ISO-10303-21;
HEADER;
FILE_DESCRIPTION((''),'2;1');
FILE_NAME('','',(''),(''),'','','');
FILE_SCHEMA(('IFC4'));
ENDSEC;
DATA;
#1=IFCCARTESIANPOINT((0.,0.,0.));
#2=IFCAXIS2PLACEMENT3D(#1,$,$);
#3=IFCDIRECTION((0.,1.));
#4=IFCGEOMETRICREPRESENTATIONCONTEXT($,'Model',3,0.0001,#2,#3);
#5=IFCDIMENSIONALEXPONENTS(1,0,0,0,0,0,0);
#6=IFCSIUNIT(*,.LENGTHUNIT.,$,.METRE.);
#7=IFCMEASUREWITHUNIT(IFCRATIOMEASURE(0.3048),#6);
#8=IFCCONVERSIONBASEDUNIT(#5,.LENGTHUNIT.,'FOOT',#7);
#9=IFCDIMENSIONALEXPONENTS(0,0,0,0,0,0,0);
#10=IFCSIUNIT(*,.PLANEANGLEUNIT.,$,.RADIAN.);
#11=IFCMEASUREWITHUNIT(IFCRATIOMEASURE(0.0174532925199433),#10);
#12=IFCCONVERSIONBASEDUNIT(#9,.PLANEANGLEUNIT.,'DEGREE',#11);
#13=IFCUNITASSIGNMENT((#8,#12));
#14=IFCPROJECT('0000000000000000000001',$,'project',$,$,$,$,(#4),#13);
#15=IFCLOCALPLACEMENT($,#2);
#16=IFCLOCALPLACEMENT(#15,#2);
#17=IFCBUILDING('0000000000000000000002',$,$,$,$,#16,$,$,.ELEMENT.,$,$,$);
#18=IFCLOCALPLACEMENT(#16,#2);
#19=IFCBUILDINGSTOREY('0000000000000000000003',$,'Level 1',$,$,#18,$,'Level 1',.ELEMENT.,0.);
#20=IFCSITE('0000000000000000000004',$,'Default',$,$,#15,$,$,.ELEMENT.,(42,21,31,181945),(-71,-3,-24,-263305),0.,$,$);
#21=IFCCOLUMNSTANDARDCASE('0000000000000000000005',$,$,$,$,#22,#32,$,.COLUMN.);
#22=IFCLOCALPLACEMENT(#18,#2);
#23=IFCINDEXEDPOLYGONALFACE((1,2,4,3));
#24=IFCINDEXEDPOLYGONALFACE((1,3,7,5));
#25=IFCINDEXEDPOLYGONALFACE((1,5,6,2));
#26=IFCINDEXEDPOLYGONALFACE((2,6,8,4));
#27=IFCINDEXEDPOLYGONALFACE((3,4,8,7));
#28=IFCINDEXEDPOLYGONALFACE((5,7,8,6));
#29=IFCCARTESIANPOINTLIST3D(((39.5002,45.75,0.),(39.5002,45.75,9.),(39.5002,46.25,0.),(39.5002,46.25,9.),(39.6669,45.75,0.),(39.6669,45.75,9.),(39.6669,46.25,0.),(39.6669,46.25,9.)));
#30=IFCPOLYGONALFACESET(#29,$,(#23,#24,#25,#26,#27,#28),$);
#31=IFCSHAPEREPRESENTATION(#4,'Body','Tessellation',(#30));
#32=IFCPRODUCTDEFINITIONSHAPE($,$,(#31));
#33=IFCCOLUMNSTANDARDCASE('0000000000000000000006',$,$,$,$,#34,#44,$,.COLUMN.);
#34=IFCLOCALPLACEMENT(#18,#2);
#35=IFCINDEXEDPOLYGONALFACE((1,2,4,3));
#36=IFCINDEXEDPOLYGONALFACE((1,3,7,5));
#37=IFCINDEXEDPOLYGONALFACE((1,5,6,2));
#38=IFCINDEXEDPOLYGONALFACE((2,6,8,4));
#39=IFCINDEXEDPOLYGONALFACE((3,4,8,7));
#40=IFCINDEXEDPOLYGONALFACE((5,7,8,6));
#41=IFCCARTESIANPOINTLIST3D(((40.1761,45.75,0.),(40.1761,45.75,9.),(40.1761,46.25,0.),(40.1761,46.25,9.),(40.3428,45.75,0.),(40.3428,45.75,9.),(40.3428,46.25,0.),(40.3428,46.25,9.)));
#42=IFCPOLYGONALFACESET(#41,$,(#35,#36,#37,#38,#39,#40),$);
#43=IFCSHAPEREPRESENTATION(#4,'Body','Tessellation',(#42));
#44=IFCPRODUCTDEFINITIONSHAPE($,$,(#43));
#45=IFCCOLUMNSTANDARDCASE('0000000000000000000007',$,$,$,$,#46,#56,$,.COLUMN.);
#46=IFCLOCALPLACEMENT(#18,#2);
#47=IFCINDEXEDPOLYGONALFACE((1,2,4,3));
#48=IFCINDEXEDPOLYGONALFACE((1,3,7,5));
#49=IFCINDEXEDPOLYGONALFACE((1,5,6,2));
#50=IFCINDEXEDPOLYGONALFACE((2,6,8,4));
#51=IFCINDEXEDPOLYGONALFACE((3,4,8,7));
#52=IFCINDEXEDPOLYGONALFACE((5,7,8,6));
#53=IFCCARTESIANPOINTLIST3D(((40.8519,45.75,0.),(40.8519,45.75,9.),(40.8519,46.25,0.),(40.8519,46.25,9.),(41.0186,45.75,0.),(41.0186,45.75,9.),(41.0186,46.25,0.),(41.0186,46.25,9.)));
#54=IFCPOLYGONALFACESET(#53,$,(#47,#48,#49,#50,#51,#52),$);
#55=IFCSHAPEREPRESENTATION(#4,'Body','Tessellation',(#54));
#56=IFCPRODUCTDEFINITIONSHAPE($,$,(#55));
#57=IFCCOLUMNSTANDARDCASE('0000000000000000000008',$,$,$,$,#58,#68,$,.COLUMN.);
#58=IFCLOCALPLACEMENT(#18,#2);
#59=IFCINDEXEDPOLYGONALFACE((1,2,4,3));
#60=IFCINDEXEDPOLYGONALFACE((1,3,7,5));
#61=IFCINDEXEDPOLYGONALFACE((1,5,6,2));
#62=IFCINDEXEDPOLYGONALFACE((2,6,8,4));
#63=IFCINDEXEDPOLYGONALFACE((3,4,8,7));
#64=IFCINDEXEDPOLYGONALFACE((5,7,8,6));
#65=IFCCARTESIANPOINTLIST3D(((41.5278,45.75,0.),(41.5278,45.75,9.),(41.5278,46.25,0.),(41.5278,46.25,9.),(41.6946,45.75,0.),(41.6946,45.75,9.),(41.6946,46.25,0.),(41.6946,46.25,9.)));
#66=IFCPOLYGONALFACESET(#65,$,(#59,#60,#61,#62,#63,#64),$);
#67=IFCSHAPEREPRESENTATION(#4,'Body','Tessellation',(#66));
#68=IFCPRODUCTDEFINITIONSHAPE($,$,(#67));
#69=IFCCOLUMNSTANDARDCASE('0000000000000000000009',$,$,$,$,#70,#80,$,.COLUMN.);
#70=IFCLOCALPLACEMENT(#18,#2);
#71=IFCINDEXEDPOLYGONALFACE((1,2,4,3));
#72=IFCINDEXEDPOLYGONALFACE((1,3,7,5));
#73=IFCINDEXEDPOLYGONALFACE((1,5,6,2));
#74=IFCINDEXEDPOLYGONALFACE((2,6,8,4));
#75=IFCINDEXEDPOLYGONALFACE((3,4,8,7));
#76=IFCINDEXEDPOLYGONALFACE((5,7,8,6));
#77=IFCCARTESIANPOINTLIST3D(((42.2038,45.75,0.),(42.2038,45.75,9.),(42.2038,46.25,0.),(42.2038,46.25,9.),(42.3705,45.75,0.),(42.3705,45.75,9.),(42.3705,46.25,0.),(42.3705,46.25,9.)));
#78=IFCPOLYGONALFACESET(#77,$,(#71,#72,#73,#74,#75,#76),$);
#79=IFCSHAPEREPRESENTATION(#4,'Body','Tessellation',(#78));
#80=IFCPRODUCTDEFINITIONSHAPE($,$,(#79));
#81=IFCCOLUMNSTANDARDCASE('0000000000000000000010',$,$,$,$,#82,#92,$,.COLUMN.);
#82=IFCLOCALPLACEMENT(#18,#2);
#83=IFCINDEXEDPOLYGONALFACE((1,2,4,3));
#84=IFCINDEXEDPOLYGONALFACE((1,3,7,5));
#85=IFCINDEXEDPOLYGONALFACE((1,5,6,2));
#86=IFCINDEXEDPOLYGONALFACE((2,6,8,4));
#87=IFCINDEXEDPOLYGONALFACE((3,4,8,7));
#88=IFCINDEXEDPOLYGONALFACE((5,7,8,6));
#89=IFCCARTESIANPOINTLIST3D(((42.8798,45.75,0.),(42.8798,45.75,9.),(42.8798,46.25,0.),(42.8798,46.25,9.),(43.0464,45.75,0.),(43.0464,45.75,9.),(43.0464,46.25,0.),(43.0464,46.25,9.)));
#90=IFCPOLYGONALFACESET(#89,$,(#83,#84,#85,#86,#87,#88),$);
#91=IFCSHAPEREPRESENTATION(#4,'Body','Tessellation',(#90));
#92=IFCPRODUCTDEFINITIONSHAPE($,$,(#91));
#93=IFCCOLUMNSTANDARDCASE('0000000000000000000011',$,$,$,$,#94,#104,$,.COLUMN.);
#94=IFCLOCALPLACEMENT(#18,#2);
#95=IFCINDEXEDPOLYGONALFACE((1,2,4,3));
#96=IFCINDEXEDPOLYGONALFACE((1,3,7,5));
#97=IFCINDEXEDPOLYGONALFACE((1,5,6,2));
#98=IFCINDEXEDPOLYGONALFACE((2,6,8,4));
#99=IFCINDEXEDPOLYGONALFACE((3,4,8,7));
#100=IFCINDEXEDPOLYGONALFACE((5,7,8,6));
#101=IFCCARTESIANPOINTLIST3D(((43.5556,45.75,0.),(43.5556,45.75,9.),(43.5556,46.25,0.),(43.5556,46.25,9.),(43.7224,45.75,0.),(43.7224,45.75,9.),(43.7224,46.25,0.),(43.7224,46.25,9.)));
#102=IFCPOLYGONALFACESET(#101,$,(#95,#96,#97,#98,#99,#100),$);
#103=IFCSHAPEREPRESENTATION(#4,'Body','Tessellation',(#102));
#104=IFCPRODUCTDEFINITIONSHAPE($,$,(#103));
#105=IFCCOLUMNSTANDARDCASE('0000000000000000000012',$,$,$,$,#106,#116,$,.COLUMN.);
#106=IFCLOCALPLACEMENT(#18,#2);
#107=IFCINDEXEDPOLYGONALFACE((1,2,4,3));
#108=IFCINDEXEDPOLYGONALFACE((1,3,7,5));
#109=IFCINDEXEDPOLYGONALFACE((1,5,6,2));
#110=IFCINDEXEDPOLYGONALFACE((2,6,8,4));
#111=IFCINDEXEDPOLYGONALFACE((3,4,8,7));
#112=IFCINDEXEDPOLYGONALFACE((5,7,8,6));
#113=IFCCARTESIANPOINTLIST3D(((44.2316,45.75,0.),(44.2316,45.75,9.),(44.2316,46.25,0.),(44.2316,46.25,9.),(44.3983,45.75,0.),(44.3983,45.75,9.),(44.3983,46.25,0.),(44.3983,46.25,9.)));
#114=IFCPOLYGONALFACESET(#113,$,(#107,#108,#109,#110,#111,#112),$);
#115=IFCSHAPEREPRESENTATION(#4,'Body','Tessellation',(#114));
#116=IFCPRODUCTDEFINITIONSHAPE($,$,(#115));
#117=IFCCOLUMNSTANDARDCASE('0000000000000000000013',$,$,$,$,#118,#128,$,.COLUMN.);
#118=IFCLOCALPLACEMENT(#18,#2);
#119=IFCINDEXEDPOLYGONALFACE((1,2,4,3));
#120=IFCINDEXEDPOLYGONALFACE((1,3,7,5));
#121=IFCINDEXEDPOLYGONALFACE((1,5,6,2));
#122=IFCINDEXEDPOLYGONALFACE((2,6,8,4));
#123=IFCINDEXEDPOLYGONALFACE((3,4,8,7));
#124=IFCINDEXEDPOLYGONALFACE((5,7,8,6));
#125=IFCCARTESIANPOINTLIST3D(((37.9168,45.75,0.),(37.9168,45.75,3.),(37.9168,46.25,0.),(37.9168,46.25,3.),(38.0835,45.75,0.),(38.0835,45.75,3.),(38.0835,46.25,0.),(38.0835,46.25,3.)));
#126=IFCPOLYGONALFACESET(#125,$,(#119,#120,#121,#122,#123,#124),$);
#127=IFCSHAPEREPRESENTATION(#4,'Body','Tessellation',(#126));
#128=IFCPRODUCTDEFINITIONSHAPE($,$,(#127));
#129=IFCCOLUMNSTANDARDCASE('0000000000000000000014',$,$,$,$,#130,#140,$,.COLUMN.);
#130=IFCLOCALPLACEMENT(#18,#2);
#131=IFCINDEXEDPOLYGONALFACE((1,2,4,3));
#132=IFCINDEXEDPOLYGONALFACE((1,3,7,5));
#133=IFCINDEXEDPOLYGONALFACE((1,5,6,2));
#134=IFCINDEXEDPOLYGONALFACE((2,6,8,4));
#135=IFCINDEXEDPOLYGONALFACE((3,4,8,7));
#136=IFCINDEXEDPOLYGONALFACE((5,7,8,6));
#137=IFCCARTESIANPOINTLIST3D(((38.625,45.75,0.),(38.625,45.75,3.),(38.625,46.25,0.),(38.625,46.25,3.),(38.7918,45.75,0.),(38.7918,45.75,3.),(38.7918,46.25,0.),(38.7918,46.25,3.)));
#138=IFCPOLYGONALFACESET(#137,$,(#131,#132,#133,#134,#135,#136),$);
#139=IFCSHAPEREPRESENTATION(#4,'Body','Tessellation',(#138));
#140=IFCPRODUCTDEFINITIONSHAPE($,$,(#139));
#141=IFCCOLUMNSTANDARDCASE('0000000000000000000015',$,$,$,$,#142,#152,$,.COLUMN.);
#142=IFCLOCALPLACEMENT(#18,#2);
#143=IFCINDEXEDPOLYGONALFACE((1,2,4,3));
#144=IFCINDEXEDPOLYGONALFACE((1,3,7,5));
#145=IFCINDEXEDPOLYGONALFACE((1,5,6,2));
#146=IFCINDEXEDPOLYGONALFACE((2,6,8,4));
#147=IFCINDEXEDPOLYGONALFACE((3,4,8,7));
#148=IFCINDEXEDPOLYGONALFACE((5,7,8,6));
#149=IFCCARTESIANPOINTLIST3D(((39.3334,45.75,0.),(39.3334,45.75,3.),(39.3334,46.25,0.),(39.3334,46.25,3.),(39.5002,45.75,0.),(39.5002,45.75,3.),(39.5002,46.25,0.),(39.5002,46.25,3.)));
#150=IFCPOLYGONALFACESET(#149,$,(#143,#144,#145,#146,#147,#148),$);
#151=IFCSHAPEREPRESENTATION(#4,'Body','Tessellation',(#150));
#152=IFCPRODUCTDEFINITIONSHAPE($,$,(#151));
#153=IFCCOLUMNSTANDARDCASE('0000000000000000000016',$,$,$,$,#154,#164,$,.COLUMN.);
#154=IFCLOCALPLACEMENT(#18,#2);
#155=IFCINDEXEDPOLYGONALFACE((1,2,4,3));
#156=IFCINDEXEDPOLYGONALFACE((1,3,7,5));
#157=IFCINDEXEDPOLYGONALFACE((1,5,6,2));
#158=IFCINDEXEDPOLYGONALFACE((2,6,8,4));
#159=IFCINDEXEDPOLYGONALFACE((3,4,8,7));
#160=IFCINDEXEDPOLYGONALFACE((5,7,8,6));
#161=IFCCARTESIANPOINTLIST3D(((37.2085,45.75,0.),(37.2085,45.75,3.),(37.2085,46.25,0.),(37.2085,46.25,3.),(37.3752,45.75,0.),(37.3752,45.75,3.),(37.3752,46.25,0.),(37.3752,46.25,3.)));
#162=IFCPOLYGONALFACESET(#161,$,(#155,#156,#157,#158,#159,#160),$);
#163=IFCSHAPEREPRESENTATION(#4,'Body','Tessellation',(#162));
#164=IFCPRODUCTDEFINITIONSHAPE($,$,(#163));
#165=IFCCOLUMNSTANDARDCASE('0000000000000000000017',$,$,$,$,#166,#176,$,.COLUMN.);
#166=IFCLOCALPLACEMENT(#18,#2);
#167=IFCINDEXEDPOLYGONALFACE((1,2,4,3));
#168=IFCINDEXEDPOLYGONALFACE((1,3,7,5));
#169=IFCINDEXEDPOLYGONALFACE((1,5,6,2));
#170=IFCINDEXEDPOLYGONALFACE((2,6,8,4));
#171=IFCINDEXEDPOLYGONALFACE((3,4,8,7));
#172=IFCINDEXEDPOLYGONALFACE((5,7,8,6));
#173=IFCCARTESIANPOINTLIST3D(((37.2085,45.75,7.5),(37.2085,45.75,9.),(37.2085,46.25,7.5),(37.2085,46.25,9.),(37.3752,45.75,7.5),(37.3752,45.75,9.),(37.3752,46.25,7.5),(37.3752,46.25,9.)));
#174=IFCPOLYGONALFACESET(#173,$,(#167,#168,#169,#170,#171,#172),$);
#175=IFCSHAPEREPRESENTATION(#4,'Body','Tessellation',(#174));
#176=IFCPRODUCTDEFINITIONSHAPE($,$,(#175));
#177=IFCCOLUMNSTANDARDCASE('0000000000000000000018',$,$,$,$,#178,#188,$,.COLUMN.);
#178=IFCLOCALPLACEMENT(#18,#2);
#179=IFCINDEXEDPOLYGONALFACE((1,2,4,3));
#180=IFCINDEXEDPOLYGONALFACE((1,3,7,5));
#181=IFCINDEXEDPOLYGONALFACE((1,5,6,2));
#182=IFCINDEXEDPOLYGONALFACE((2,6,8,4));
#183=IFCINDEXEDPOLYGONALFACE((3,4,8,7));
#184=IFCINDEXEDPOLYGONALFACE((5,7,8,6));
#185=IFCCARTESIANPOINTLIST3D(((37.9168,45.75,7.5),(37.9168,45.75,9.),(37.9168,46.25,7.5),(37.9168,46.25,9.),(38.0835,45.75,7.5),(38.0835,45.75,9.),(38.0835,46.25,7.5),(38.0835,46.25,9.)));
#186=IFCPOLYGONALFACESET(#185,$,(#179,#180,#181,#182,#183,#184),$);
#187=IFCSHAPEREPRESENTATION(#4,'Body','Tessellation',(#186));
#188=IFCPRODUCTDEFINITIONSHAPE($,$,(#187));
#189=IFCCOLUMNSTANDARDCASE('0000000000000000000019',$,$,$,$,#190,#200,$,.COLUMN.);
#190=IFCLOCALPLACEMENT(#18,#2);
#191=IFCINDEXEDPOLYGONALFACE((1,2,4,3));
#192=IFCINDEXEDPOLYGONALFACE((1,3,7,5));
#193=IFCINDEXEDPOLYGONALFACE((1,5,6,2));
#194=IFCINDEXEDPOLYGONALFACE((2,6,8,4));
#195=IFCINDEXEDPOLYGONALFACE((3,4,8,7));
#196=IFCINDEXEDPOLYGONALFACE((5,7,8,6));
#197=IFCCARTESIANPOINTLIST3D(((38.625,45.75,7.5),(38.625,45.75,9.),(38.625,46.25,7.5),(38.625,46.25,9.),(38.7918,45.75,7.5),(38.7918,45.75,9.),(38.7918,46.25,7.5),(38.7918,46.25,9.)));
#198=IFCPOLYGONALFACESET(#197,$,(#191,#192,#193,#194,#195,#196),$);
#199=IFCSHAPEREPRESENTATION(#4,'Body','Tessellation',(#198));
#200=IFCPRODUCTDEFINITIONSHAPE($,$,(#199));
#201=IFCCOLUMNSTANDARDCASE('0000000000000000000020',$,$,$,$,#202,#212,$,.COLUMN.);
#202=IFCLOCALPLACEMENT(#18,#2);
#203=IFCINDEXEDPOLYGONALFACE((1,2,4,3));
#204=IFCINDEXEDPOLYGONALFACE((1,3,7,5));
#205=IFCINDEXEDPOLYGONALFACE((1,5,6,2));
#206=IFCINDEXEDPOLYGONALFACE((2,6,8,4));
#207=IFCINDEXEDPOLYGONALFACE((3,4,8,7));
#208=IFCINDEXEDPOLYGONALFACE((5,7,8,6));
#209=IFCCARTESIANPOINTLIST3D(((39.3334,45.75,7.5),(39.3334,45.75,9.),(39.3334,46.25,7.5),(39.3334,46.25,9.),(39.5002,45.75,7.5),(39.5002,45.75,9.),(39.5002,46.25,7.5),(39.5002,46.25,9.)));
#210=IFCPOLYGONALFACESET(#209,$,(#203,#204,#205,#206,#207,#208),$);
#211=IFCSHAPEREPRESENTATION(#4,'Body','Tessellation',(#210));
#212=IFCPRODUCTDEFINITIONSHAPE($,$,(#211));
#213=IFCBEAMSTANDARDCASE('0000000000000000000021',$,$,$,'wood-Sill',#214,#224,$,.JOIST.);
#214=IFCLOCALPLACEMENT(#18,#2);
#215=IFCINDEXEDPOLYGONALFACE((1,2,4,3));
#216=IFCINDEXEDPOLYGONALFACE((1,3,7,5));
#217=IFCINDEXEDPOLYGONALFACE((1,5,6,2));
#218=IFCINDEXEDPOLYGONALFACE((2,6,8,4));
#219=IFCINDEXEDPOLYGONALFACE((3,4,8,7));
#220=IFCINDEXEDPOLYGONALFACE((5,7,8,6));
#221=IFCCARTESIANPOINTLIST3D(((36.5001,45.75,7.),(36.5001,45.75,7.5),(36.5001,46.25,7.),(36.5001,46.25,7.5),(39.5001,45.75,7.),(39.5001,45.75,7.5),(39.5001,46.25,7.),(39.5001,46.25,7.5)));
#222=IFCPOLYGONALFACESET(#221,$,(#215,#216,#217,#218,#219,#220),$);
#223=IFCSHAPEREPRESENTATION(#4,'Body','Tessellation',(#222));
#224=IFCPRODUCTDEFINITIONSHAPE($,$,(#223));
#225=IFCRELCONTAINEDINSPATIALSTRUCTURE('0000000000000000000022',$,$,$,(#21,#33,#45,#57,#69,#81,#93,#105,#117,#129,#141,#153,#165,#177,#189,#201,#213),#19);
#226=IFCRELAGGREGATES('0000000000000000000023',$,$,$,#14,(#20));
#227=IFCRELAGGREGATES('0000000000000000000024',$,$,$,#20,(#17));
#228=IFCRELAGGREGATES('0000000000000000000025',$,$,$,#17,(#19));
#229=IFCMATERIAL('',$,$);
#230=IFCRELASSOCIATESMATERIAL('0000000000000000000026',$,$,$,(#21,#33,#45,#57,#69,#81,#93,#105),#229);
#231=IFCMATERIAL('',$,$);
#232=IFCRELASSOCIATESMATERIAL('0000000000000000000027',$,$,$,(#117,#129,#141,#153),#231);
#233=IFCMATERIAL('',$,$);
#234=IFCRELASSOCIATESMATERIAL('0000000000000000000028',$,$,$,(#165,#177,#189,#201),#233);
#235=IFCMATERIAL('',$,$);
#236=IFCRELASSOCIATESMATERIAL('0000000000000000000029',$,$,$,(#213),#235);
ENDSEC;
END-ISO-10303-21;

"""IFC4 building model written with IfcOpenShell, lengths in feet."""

from ifc_helpers import new_model, entity, si_unit, converted_unit, direction, frame, origin, place, context, project, spatial, rectangle, extrude, material, element, save


model = new_model("IFC4")

# Units and contexts
model_context = context("Model", 3, precision=0.0001, world=origin(), true_north=direction((0.0, 1.0)))
ifc_project = project(units=[converted_unit("LENGTHUNIT", "FOOT", entity("IfcRatioMeasure", 0.3048), si_unit("LENGTHUNIT", "METRE"), dimensions=[1, 0, 0, 0, 0, 0, 0]), converted_unit("PLANEANGLEUNIT", "DEGREE", entity("IfcRatioMeasure", 0.0174532925199433), si_unit("PLANEANGLEUNIT", "RADIAN"), dimensions=[0, 0, 0, 0, 0, 0, 0])], contexts=[model_context])

# Site, building, storey
site_placement = place(None, origin())
site = spatial("IfcSite", under=ifc_project, at=site_placement, Name="Default", CompositionType="ELEMENT", RefLatitude=(42, 21, 31, 181945), RefLongitude=(-71, -3, -24, -263305), RefElevation=0.0)
building_placement = place(site_placement, origin())
building = spatial("IfcBuilding", under=site, at=building_placement, CompositionType="ELEMENT")
storey_placement = place(building_placement, origin())
storey = spatial("IfcBuildingStorey", under=building, at=storey_placement, Name="Level 1", LongName="Level 1", CompositionType="ELEMENT", Elevation=0.0)

# Columns
ifc_material_1 = material(Name="")
placement_1 = place(storey_placement, frame((-0.25, 46.0, 0.0)))
for number, where, z_axis, x_axis in (
    (1, (39.8335, 0.0, 0.0), (0.0, 0.0, 1.0), (1.0, 0.0, 0.0)),
    (2, (40.5094, 0.0, 0.0), (0.0, 0.0, 1.0), (1.0, 0.0, 0.0)),
    (3, (41.1853, 0.0, 0.0), (0.0, 0.0, 1.0), (1.0, 0.0, 0.0)),
    (4, (41.8612, 0.0, 0.0), (0.0, 0.0, 1.0), (1.0, 0.0, 0.0)),
    (5, (42.5371, 0.0, 0.0), (0.0, 0.0, 1.0), (1.0, 0.0, 0.0)),
    (6, (43.2131, 0.0, 0.0), (0.0, 0.0, 1.0), (1.0, 0.0, 0.0)),
    (7, (43.889, 0.0, 0.0), (0.0, 0.0, 1.0), (1.0, 0.0, 0.0)),
    (8, (44.5649, 0.0, 0.0), (0.0, 0.0, 1.0), (1.0, 0.0, 0.0)),
):
    element("IfcColumnStandardCase", number, at=place(placement_1, frame(where, z_axis=z_axis, x_axis=x_axis)), inside=storey, material=ifc_material_1, PredefinedType="COLUMN", context=model_context, shape_type="SweptSolid", body=[
        extrude(rectangle(XDim=0.1667, YDim=0.5), origin(), (0.0, 0.0, 1.0), 9.0),
    ])
ifc_material_2 = material(Name="")
for number, where, z_axis, x_axis in (
    (9, (38.2501, 0.0, 0.0), (0.0, 0.0, 1.0), (1.0, 0.0, 0.0)),
    (10, (38.9584, 0.0, 0.0), (0.0, 0.0, 1.0), (1.0, 0.0, 0.0)),
    (11, (39.6668, 0.0, 0.0), (0.0, 0.0, 1.0), (1.0, 0.0, 0.0)),
    (12, (37.5418, 0.0, 0.0), (0.0, 0.0, 1.0), (1.0, 0.0, 0.0)),
):
    element("IfcColumnStandardCase", number, at=place(placement_1, frame(where, z_axis=z_axis, x_axis=x_axis)), inside=storey, material=ifc_material_2, PredefinedType="COLUMN", context=model_context, shape_type="SweptSolid", body=[
        extrude(rectangle(XDim=0.1667, YDim=0.5), origin(), (0.0, 0.0, 1.0), 3.0),
    ])
ifc_material_3 = material(Name="")
for number, where, z_axis, x_axis in (
    (13, (37.5418, 0.0, 7.5), (0.0, 0.0, 1.0), (1.0, 0.0, 0.0)),
    (14, (38.2501, 0.0, 7.5), (0.0, 0.0, 1.0), (1.0, 0.0, 0.0)),
    (15, (38.9584, 0.0, 7.5), (0.0, 0.0, 1.0), (1.0, 0.0, 0.0)),
    (16, (39.6668, 0.0, 7.5), (0.0, 0.0, 1.0), (1.0, 0.0, 0.0)),
):
    element("IfcColumnStandardCase", number, at=place(placement_1, frame(where, z_axis=z_axis, x_axis=x_axis)), inside=storey, material=ifc_material_3, PredefinedType="COLUMN", context=model_context, shape_type="SweptSolid", body=[
        extrude(rectangle(XDim=0.1667, YDim=0.5), origin(), (0.0, 0.0, 1.0), 1.5),
    ])

# Beam
ifc_material_4 = material(Name="")
for number, where, z_axis, x_axis in (
    (17, (38.2501, 0.0, 7.0), (0.0, 0.0, 1.0), (1.0, 0.0, 0.0)),
):
    element("IfcBeamStandardCase", number, at=place(placement_1, frame(where, z_axis=z_axis, x_axis=x_axis)), inside=storey, material=ifc_material_4, ObjectType="wood-Sill", PredefinedType="JOIST", context=model_context, shape_type="SweptSolid", body=[
        extrude(rectangle(XDim=3.0, YDim=0.5), origin(), (0.0, 0.0, 1.0), 0.5),
    ])

save(model, "model.ifc")
